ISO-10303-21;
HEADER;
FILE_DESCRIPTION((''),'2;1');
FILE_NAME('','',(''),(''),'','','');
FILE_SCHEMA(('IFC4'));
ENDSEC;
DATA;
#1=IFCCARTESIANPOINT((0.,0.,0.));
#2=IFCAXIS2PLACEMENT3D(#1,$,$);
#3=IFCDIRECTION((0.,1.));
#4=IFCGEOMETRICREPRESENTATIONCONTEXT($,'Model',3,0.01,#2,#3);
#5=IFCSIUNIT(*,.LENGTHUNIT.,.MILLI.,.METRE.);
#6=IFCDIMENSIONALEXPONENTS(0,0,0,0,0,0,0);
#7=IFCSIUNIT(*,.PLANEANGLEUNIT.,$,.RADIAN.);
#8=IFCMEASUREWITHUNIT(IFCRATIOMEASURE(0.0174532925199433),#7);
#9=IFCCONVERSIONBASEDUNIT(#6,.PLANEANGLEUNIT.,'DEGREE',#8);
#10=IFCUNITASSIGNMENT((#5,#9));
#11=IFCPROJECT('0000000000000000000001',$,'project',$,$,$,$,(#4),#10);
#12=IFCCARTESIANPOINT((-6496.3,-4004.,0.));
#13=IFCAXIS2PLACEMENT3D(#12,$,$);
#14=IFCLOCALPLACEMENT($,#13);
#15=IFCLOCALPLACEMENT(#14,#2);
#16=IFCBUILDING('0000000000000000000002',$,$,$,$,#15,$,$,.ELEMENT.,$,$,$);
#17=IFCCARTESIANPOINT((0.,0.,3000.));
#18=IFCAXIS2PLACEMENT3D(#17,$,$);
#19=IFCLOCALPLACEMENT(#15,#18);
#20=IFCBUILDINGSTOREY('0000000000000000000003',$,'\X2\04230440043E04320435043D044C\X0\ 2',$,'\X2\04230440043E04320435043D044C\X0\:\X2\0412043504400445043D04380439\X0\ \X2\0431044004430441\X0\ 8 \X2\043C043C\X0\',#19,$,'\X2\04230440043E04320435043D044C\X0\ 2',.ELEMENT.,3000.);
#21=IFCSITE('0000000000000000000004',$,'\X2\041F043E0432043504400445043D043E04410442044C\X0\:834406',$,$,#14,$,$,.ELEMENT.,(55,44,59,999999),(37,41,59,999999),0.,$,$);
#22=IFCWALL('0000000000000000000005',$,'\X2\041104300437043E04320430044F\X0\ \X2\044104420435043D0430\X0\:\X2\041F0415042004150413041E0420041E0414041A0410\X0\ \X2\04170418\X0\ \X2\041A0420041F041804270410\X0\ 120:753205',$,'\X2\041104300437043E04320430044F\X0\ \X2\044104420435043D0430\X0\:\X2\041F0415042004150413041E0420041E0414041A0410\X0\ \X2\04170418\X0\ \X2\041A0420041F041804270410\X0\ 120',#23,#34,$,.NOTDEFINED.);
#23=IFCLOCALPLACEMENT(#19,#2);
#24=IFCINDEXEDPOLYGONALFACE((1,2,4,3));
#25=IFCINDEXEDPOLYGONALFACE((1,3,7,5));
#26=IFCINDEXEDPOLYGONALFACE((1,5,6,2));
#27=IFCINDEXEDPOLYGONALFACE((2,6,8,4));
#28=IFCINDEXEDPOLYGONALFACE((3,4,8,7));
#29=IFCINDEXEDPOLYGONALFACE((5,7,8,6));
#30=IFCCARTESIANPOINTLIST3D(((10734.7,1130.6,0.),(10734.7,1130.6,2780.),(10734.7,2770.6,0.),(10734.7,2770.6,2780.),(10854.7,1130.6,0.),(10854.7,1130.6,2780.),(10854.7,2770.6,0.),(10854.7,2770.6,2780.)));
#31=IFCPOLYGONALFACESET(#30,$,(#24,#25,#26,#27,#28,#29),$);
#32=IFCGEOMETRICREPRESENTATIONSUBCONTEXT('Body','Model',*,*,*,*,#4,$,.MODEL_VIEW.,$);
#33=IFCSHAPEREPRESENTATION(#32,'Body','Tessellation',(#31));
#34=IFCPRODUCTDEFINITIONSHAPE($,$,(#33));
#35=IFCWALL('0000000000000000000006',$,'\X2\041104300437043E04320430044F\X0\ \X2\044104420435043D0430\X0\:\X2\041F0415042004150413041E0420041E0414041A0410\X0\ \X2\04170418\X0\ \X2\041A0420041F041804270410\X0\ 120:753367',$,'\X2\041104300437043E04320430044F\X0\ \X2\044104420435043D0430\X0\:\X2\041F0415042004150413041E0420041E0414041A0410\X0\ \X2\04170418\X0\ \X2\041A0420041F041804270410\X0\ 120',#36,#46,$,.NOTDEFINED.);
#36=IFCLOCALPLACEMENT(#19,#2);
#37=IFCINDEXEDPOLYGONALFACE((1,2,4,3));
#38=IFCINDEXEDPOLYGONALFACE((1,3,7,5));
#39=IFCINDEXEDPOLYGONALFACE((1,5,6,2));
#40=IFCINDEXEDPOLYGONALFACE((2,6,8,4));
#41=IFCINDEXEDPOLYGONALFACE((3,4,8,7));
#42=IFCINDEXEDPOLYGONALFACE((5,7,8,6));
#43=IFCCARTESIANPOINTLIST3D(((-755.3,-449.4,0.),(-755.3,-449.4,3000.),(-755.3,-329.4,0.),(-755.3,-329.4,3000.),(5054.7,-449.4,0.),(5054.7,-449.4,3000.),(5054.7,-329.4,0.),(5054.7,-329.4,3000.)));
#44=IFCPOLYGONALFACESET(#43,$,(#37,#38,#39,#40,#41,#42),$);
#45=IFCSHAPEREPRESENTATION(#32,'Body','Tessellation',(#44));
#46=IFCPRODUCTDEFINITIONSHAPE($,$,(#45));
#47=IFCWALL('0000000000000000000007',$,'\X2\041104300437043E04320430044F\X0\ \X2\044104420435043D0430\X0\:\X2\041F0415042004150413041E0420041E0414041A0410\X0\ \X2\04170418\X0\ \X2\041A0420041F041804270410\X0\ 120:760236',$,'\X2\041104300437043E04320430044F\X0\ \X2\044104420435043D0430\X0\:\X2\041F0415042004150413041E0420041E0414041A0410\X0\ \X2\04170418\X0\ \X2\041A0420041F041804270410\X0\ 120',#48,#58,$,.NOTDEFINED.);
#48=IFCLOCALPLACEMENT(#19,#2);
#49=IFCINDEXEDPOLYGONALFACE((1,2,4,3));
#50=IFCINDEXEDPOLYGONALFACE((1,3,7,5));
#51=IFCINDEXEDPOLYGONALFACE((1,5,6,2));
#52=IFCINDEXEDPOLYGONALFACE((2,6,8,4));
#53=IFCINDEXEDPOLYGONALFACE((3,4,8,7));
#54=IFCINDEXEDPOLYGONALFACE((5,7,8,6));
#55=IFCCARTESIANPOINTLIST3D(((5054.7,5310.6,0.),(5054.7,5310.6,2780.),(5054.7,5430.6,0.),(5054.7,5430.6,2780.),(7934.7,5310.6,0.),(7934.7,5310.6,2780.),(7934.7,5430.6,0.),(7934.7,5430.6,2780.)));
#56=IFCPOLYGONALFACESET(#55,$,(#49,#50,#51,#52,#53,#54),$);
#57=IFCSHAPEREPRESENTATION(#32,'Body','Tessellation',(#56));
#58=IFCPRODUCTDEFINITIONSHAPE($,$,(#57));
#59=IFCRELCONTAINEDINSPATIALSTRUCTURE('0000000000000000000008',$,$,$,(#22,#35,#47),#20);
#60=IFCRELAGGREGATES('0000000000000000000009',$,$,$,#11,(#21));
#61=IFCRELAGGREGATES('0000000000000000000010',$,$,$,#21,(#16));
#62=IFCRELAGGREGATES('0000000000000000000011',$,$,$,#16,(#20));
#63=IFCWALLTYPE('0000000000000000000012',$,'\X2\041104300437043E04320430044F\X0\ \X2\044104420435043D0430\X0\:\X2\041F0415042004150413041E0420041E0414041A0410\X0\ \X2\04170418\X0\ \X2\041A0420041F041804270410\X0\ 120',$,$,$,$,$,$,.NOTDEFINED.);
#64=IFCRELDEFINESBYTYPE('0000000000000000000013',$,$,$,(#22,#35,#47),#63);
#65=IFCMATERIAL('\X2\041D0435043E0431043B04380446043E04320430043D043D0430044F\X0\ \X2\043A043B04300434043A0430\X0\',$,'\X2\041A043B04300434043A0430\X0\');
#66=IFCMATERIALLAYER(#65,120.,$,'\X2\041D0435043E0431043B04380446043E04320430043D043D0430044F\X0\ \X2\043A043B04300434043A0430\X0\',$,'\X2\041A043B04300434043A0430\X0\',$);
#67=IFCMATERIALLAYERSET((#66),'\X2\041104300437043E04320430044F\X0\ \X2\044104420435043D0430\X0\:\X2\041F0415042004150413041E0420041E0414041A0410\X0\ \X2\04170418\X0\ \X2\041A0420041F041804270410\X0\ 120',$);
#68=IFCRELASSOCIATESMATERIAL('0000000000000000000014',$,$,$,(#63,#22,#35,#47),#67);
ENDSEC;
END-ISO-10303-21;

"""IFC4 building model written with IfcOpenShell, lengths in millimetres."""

from ifc_helpers import new_model, entity, si_unit, converted_unit, direction, frame, origin, place, context, subcontext, project, spatial, indexed_curve, outline, extrude, material, layer, layer_set, type_object, element, save


model = new_model("IFC4")

# Units and contexts
model_context = context("Model", 3, precision=0.01, world=origin(), true_north=direction((0.0, 1.0)))
body_context = subcontext(model_context, "Body", "Model", "MODEL_VIEW")
ifc_project = project(units=[si_unit("LENGTHUNIT", "METRE", prefix="MILLI"), converted_unit("PLANEANGLEUNIT", "DEGREE", entity("IfcRatioMeasure", 0.0174532925199433), si_unit("PLANEANGLEUNIT", "RADIAN"), dimensions=[0, 0, 0, 0, 0, 0, 0])], contexts=[model_context])

# Site, building, storey
site_placement = place(None, frame((-6496.3, -4004.0, 0.0)))
site = spatial("IfcSite", under=ifc_project, at=site_placement, Name="Поверхность:834406", CompositionType="ELEMENT", RefLatitude=(55, 44, 59, 999999), RefLongitude=(37, 41, 59, 999999), RefElevation=0.0)
building_placement = place(site_placement, origin())
building = spatial("IfcBuilding", under=site, at=building_placement, CompositionType="ELEMENT")
storey_placement = place(building_placement, frame((0.0, 0.0, 3000.0)))
storey = spatial("IfcBuildingStorey", under=building, at=storey_placement, Name="Уровень 2", ObjectType="Уровень:Верхний брус 8 мм", LongName="Уровень 2", CompositionType="ELEMENT", Elevation=3000.0)

# Walls
ifc_material_1 = material(Name="Необлицованная кладка", Category="Кладка")
ifc_layer_1 = layer(ifc_material_1, 120.0, Name="Необлицованная кладка", Category="Кладка")
ifc_layer_set_1 = layer_set([ifc_layer_1], Name="Базовая стена:ПЕРЕГОРОДКА ЗИ КРПИЧА 120")
wall_type = type_object("IfcWallType", Name="Базовая стена:ПЕРЕГОРОДКА ЗИ КРПИЧА 120", PredefinedType="NOTDEFINED", material=ifc_layer_set_1)
wall_1_placement = place(storey_placement, frame((10794.7, 2770.6, 0.0), z_axis=(0.0, 0.0, 1.0), x_axis=(0.0, -1.0, 0.0)))
element("IfcWall", 1, at=wall_1_placement, inside=storey, type_object=wall_type, material=ifc_layer_set_1, Name="Базовая стена:ПЕРЕГОРОДКА ЗИ КРПИЧА 120:753205", ObjectType="Базовая стена:ПЕРЕГОРОДКА ЗИ КРПИЧА 120", PredefinedType="NOTDEFINED", context=body_context, shape_type="SweptSolid", body=[
    extrude(outline(indexed_curve([(1640.0, 60.0), (0.0, 60.0), (0.0, -60.0), (1640.0, -60.0), (1640.0, 60.0)], self_intersect=False)), origin(), (0.0, 0.0, 1.0), 2780.0),
])
wall_2_placement = place(storey_placement, frame((-755.3, -389.4, 0.0)))
element("IfcWall", 2, at=wall_2_placement, inside=storey, type_object=wall_type, material=ifc_layer_set_1, Name="Базовая стена:ПЕРЕГОРОДКА ЗИ КРПИЧА 120:753367", ObjectType="Базовая стена:ПЕРЕГОРОДКА ЗИ КРПИЧА 120", PredefinedType="NOTDEFINED", context=body_context, shape_type="SweptSolid", body=[
    extrude(outline(indexed_curve([(5810.0, 60.0), (0.0, 60.0), (0.0, -60.0), (5810.0, -60.0), (5810.0, 60.0)], self_intersect=False)), origin(), (0.0, 0.0, 1.0), 3000.0),
])
wall_3_placement = place(storey_placement, frame((7934.7, 5370.6, 0.0), z_axis=(0.0, 0.0, 1.0), x_axis=(-1.0, 0.0, 0.0)))
element("IfcWall", 3, at=wall_3_placement, inside=storey, type_object=wall_type, material=ifc_layer_set_1, Name="Базовая стена:ПЕРЕГОРОДКА ЗИ КРПИЧА 120:760236", ObjectType="Базовая стена:ПЕРЕГОРОДКА ЗИ КРПИЧА 120", PredefinedType="NOTDEFINED", context=body_context, shape_type="SweptSolid", body=[
    extrude(outline(indexed_curve([(2880.0, 60.0), (0.0, 60.0), (0.0, -60.0), (2880.0, -60.0), (2880.0, 60.0)], self_intersect=False)), origin(), (0.0, 0.0, 1.0), 2780.0),
])

save(model, "model.ifc")
